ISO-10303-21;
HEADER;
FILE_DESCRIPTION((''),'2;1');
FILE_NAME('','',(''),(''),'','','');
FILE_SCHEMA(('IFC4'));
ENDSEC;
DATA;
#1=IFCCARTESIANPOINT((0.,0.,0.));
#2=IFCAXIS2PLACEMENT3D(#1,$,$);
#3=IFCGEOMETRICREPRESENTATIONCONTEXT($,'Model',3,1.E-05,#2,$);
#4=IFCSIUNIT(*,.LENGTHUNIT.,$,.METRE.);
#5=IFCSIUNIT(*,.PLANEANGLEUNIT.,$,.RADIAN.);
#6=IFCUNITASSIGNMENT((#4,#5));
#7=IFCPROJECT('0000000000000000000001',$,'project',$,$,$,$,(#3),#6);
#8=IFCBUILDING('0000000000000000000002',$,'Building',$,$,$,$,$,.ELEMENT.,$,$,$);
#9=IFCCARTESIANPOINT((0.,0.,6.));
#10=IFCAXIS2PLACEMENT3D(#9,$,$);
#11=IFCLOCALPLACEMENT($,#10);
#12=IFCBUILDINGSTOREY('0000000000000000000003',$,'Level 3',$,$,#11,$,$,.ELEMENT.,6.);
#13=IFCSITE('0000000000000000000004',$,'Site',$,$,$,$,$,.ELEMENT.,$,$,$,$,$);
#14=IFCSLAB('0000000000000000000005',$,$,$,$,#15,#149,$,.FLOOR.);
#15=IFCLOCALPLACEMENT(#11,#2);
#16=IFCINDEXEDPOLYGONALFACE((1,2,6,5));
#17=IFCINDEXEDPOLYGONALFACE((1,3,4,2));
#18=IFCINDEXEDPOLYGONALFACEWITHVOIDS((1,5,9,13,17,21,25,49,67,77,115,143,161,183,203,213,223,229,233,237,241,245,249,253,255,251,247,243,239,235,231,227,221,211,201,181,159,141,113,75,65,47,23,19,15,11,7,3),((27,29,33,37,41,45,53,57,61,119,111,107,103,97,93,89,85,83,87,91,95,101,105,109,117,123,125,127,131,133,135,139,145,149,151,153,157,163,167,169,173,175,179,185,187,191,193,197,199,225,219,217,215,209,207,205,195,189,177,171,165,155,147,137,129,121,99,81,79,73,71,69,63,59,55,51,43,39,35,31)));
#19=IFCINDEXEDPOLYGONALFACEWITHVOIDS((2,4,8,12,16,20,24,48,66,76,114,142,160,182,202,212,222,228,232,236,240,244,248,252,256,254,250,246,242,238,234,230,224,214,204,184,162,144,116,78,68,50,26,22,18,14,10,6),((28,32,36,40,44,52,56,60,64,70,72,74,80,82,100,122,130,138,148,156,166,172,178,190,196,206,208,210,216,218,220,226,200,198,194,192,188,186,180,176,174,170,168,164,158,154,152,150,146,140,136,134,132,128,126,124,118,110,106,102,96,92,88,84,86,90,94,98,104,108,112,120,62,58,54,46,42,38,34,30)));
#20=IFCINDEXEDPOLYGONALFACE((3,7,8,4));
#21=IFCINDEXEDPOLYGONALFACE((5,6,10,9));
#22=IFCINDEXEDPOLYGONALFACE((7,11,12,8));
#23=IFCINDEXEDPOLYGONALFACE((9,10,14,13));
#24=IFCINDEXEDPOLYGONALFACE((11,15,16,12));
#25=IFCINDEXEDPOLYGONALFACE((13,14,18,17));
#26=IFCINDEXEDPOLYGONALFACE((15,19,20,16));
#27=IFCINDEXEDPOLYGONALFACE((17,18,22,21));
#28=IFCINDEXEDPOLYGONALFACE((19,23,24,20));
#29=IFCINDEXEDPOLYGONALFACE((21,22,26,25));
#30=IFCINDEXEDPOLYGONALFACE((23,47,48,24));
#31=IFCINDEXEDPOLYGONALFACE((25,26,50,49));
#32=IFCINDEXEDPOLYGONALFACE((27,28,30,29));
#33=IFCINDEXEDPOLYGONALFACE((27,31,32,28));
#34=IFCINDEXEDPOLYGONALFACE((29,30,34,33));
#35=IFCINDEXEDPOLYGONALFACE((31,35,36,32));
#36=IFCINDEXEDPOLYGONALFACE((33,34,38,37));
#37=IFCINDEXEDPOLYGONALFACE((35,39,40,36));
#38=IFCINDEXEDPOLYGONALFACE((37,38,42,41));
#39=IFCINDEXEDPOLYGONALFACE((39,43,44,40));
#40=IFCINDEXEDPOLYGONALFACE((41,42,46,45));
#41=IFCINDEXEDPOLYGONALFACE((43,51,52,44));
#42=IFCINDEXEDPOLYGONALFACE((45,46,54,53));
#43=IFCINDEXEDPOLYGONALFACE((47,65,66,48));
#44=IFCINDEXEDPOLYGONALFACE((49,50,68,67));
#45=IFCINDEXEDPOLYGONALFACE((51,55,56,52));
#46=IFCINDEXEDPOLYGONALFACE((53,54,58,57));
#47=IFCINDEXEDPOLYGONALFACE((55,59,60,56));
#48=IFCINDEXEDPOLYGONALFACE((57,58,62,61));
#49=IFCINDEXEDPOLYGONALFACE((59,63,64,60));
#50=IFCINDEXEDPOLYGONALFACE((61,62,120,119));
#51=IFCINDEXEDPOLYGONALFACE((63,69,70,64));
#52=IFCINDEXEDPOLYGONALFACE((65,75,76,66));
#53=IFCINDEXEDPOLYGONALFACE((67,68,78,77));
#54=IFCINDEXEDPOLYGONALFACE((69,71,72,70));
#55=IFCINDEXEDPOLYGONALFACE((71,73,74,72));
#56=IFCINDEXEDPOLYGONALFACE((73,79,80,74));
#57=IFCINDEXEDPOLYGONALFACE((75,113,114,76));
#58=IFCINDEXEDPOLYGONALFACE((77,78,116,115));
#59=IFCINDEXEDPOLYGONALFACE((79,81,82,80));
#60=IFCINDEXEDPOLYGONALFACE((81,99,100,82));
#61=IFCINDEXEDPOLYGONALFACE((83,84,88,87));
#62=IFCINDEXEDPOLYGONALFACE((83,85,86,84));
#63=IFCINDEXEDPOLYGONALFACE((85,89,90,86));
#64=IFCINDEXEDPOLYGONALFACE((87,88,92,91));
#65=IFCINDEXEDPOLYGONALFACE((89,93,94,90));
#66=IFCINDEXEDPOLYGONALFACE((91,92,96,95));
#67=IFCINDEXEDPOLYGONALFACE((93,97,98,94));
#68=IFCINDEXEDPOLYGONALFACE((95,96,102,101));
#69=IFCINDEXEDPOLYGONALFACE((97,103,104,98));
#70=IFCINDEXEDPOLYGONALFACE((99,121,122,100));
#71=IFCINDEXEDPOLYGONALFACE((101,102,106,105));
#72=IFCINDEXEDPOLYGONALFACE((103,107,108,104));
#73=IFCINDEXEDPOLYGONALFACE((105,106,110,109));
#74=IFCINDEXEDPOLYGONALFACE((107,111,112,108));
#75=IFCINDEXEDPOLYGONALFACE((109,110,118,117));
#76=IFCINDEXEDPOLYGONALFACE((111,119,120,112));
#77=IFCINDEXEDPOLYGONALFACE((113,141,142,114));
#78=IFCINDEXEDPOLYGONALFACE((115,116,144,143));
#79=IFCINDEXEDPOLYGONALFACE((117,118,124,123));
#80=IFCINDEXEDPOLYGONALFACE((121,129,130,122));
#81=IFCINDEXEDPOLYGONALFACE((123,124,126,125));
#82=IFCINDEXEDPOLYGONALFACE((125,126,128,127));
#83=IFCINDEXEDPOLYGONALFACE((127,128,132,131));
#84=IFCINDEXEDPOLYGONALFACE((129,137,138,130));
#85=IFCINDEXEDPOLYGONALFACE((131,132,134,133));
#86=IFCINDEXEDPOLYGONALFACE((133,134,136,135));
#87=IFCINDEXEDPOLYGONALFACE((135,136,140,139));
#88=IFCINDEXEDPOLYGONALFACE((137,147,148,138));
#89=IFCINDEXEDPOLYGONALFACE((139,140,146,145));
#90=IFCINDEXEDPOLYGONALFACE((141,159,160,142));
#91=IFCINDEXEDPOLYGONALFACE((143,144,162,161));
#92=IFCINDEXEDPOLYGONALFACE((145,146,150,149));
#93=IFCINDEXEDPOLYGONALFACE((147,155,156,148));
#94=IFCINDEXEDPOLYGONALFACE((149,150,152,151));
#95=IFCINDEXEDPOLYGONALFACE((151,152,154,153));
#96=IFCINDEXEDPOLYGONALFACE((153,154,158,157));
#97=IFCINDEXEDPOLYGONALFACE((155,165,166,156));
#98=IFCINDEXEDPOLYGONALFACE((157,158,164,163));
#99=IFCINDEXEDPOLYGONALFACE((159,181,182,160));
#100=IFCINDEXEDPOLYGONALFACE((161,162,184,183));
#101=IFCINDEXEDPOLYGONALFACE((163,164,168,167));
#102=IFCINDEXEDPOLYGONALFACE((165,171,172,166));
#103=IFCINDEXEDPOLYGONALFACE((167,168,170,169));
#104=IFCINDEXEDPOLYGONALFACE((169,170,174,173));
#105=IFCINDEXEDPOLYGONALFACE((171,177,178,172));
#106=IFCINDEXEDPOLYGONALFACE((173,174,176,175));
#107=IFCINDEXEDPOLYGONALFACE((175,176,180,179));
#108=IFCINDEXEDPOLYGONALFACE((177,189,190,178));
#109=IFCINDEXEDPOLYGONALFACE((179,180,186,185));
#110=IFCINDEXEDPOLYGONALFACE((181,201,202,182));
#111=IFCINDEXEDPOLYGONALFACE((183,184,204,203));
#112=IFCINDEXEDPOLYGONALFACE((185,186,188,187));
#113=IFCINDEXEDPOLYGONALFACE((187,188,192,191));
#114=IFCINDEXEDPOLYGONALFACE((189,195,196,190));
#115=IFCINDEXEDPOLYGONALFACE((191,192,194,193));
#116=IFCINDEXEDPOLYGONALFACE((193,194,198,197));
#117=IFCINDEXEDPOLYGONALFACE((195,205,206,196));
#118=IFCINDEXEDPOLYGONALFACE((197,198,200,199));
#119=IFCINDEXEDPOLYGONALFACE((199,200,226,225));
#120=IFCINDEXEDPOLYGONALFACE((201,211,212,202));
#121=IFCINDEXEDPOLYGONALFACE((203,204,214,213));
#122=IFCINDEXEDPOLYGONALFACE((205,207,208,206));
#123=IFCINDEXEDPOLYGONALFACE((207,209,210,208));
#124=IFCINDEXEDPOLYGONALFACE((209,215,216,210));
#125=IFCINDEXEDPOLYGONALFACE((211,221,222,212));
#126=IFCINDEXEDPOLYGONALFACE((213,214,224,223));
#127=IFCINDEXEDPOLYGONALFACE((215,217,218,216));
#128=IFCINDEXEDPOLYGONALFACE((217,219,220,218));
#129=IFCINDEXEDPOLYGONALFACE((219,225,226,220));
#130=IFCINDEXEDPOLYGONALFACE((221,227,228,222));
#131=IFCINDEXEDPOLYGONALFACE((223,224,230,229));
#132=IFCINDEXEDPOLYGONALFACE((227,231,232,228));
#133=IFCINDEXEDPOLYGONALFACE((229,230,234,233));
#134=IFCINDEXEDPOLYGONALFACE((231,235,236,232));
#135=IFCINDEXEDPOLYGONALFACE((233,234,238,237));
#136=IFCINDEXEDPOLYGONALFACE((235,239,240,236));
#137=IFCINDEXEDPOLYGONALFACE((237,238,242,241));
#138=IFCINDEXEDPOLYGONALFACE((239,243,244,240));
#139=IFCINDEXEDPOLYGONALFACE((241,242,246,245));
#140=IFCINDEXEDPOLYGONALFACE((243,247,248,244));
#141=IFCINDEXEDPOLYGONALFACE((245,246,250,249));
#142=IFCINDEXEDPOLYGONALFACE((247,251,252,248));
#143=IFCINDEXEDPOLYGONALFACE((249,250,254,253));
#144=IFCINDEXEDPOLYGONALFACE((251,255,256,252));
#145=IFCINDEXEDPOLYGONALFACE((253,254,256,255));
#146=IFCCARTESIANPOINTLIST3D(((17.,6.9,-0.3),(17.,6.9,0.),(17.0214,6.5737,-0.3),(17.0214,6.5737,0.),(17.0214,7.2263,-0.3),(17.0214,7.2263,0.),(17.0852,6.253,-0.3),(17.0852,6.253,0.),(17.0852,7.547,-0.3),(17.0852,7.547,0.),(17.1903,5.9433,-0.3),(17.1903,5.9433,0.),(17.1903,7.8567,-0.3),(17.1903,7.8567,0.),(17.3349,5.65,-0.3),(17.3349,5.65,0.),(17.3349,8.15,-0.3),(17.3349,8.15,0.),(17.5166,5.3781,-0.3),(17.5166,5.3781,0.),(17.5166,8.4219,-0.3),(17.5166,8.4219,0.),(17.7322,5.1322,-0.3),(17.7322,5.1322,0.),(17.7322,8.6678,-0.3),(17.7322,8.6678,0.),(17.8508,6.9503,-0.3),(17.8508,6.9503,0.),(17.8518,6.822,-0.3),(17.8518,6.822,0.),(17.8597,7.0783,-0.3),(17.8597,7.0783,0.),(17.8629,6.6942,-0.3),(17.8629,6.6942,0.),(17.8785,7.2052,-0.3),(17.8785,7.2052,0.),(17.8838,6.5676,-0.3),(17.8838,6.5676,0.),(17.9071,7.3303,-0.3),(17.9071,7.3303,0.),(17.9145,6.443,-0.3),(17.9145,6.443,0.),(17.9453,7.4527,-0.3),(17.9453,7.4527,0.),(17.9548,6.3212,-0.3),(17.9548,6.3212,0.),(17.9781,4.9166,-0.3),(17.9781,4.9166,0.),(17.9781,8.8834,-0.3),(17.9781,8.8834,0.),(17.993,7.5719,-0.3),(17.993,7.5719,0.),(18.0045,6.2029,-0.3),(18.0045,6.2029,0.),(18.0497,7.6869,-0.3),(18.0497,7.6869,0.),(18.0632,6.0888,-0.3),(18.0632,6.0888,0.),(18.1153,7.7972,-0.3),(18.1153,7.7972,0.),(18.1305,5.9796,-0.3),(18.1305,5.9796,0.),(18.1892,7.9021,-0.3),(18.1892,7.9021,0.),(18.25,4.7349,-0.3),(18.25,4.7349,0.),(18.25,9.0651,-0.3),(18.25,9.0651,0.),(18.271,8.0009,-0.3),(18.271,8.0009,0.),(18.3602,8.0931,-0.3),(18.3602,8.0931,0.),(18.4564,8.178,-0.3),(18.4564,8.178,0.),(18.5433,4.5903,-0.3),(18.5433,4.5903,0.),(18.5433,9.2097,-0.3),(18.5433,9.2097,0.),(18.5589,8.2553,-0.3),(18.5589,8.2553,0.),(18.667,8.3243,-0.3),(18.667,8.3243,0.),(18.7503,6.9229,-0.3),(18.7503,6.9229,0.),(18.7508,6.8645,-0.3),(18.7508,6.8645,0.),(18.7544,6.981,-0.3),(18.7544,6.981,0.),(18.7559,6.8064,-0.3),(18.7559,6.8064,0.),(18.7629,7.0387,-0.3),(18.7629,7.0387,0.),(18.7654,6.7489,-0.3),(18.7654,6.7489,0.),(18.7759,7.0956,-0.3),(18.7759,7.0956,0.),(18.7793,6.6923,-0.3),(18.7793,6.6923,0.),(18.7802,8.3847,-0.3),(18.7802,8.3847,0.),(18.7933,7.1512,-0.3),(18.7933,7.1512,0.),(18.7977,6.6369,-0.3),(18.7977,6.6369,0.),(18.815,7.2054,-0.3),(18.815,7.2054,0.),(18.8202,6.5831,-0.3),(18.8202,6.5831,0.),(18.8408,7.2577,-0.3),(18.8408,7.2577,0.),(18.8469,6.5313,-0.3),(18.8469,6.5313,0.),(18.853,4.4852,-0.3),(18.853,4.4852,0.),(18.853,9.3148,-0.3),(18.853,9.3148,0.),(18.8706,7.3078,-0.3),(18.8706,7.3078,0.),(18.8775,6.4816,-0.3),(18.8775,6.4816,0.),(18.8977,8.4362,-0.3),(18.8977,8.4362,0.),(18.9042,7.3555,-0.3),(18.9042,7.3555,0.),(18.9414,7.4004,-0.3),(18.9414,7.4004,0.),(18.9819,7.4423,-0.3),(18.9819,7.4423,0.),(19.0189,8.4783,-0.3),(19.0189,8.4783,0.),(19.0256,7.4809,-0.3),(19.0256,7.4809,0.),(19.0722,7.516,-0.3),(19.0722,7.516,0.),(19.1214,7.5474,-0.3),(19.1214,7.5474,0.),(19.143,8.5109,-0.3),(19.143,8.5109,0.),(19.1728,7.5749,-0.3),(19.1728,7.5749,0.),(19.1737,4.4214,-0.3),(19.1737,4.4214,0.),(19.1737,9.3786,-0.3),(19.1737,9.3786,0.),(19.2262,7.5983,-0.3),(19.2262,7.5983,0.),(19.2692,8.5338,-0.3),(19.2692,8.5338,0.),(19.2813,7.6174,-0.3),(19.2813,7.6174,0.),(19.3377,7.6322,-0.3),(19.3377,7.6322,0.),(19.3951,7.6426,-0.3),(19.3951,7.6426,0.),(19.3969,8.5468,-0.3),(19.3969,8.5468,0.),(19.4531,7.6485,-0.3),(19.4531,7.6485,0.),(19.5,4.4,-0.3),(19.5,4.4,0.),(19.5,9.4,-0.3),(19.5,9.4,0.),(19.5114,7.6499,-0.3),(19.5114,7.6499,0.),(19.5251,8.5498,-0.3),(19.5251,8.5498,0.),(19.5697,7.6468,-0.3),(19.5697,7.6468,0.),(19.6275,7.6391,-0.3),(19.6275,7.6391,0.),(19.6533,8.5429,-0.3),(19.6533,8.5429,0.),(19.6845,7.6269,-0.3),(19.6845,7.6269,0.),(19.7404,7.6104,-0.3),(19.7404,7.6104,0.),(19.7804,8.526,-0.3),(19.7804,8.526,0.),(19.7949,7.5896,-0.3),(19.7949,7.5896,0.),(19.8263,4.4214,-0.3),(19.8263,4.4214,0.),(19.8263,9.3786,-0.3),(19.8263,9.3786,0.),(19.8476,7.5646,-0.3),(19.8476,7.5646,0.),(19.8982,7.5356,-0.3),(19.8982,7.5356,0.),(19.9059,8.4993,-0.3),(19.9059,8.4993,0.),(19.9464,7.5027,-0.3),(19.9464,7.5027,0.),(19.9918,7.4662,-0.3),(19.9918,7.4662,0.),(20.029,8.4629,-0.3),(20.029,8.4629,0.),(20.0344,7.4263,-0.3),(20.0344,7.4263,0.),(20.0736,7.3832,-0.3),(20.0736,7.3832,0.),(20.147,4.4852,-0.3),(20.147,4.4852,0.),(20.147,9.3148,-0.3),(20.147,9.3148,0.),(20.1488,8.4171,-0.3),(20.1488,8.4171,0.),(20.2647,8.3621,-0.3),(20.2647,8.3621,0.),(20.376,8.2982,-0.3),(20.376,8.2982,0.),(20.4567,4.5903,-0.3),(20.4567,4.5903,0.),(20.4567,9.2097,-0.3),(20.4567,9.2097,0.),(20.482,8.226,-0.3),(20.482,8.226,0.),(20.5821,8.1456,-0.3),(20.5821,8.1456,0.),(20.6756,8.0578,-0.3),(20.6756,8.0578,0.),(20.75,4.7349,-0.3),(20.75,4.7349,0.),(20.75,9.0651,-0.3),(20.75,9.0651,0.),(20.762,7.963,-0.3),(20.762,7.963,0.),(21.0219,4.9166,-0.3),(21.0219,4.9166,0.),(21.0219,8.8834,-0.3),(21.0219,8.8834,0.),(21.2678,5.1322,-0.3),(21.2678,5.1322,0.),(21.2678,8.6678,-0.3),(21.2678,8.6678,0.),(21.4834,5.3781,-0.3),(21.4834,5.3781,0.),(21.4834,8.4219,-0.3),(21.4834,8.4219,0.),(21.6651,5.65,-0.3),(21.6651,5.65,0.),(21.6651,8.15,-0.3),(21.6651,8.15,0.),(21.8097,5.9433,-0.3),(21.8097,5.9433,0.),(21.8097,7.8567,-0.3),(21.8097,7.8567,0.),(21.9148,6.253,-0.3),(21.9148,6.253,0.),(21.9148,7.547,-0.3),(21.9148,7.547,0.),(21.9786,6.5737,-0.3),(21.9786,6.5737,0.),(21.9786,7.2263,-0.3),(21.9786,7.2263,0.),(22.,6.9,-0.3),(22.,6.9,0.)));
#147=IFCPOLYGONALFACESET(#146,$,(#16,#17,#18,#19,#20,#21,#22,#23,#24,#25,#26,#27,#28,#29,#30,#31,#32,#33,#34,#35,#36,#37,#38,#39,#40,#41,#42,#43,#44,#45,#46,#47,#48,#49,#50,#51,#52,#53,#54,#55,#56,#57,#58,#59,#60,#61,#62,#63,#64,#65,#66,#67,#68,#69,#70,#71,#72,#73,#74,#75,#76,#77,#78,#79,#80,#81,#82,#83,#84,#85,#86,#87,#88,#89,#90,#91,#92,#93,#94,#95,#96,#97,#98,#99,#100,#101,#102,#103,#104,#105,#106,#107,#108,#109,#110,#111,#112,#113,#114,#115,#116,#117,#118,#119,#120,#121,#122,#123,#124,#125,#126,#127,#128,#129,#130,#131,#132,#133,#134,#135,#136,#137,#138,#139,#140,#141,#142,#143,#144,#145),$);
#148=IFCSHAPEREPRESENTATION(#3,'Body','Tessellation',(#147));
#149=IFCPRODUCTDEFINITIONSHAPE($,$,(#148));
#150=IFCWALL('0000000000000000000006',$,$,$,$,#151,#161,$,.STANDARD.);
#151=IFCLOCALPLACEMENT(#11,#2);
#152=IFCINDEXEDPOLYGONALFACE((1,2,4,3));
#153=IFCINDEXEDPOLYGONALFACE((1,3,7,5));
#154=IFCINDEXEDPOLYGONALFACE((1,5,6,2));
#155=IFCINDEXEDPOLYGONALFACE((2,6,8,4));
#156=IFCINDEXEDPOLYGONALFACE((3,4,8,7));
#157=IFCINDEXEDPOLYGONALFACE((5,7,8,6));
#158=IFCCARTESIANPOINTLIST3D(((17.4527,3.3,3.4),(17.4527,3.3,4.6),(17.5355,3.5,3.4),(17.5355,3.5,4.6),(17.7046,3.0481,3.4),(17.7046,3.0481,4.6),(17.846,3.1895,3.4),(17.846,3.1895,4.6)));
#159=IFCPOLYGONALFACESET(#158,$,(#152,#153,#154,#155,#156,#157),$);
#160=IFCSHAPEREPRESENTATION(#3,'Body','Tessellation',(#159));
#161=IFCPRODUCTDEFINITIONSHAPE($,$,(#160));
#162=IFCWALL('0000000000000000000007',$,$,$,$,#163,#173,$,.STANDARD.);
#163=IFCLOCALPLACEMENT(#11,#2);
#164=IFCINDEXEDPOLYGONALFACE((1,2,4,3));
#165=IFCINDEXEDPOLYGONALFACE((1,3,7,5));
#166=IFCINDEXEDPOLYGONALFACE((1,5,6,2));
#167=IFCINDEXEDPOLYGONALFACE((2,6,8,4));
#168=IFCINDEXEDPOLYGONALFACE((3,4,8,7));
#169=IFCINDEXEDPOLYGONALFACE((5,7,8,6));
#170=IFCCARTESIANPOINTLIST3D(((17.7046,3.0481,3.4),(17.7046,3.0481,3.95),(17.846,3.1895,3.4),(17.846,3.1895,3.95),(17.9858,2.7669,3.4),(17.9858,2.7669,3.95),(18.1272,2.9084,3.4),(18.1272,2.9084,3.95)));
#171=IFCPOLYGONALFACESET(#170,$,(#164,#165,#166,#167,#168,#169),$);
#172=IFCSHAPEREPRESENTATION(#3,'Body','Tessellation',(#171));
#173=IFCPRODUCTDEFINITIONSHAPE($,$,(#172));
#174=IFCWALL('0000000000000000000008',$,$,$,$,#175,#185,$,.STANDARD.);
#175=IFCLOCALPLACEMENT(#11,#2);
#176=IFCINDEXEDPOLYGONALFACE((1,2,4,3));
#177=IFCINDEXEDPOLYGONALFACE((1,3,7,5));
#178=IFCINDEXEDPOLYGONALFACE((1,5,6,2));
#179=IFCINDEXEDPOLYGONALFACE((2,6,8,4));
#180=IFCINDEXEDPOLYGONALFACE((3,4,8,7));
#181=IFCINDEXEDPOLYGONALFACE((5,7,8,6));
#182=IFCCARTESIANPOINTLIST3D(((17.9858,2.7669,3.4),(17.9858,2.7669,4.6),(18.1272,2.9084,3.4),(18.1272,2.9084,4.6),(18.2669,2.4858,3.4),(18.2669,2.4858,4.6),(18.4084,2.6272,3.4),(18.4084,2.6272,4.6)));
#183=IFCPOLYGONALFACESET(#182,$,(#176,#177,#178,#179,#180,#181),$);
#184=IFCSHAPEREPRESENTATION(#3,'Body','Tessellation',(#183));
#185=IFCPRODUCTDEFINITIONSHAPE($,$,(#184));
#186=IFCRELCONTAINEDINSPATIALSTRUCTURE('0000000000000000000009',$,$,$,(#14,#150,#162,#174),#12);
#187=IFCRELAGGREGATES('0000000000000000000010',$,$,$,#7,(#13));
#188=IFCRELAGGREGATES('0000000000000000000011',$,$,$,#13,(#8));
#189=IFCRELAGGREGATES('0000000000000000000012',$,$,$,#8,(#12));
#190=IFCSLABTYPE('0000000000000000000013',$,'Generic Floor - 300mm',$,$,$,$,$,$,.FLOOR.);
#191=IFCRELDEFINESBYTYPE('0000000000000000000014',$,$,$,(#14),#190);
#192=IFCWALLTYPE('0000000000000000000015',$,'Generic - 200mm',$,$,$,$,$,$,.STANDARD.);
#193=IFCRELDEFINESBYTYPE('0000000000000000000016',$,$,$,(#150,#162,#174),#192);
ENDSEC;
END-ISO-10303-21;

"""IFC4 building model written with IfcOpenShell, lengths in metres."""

from ifc_helpers import new_model, si_unit, frame, frame_2d, origin, place, context, project, spatial, polyline, rectangle, outline, extrude, type_object, element, save


model = new_model("IFC4")

# Units and contexts
model_context = context("Model", 3, precision=1e-05, world=origin())
ifc_project = project(units=[si_unit("LENGTHUNIT", "METRE"), si_unit("PLANEANGLEUNIT", "RADIAN")], contexts=[model_context])

# Site, building, storey
site = spatial("IfcSite", under=ifc_project, Name="Site", CompositionType="ELEMENT")
building = spatial("IfcBuilding", under=site, Name="Building", CompositionType="ELEMENT")
storey_placement = place(None, frame((0.0, 0.0, 6.0)))
storey = spatial("IfcBuildingStorey", under=building, at=storey_placement, Name="Level 3", CompositionType="ELEMENT", Elevation=6.0)

# Shared definitions
slab_type = type_object("IfcSlabType", Name="Generic Floor - 300mm", PredefinedType="FLOOR")

# Slab, opening
slab_1_placement = place(None, frame((0.0, 0.0, 6.0)))
slab_1 = element("IfcSlab", 1, at=slab_1_placement, inside=storey, type_object=slab_type, PredefinedType="FLOOR", context=model_context, shape_type="SweptSolid", body=[
    extrude(outline(polyline([(22.0, 6.9), (21.9786, 7.2263), (21.9148, 7.547), (21.8097, 7.8567), (21.6651, 8.15), (21.4834, 8.4219), (21.2678, 8.6678), (21.0219, 8.8834), (20.75, 9.0651), (20.4567, 9.2097), (20.147, 9.3148), (19.8263, 9.3786), (19.5, 9.4), (19.1737, 9.3786), (18.853, 9.3148), (18.5433, 9.2097), (18.25, 9.0651), (17.9781, 8.8834), (17.7322, 8.6678), (17.5166, 8.4219), (17.3349, 8.15), (17.1903, 7.8567), (17.0852, 7.547), (17.0214, 7.2263), (17.0, 6.9), (17.0214, 6.5737), (17.0852, 6.253), (17.1903, 5.9433), (17.3349, 5.65), (17.5166, 5.3781), (17.7322, 5.1322), (17.9781, 4.9166), (18.25, 4.7349), (18.5433, 4.5903), (18.853, 4.4852), (19.1737, 4.4214), (19.5, 4.4), (19.8263, 4.4214), (20.147, 4.4852), (20.4567, 4.5903), (20.75, 4.7349), (21.0219, 4.9166), (21.2678, 5.1322), (21.4834, 5.3781), (21.6651, 5.65), (21.8097, 5.9433), (21.9148, 6.253), (21.9786, 6.5737), (22.0, 6.9)])), origin(), (0.0, 0.0, -1.0), 0.3),
])
opening_1_placement = place(None, frame((0.0, 0.0, 6.001)))
element("IfcOpeningElement", 2, at=opening_1_placement, cuts=slab_1, PredefinedType="OPENING", context=model_context, shape_type="SweptSolid", body=[
    extrude(outline(polyline([(17.8597, 7.0783), (17.8508, 6.9503), (17.8518, 6.822), (17.8629, 6.6942), (17.8838, 6.5676), (17.9145, 6.443), (17.9548, 6.3212), (18.0045, 6.2029), (18.0632, 6.0888), (18.1305, 5.9796), (18.8775, 6.4816), (18.8469, 6.5313), (18.8202, 6.5831), (18.7977, 6.6369), (18.7793, 6.6923), (18.7654, 6.7489), (18.7559, 6.8064), (18.7508, 6.8645), (18.7503, 6.9229), (18.7544, 6.981), (18.7629, 7.0387), (18.7759, 7.0956), (18.7933, 7.1512), (18.815, 7.2054), (18.8408, 7.2577), (18.8706, 7.3078), (18.9042, 7.3555), (18.9414, 7.4004), (18.9819, 7.4423), (19.0256, 7.4809), (19.0722, 7.516), (19.1214, 7.5474), (19.1728, 7.5749), (19.2262, 7.5983), (19.2813, 7.6174), (19.3377, 7.6322), (19.3951, 7.6426), (19.4531, 7.6485), (19.5114, 7.6499), (19.5697, 7.6468), (19.6275, 7.6391), (19.6845, 7.6269), (19.7404, 7.6104), (19.7949, 7.5896), (19.8476, 7.5646), (19.8982, 7.5356), (19.9464, 7.5027), (19.9918, 7.4662), (20.0344, 7.4263), (20.0736, 7.3832), (20.762, 7.963), (20.6756, 8.0578), (20.5821, 8.1456), (20.482, 8.226), (20.376, 8.2982), (20.2647, 8.3621), (20.1488, 8.4171), (20.029, 8.4629), (19.9059, 8.4993), (19.7804, 8.526), (19.6533, 8.5429), (19.5251, 8.5498), (19.3969, 8.5468), (19.2692, 8.5338), (19.143, 8.5109), (19.0189, 8.4783), (18.8977, 8.4362), (18.7802, 8.3847), (18.667, 8.3243), (18.5589, 8.2553), (18.4564, 8.178), (18.3602, 8.0931), (18.271, 8.0009), (18.1892, 7.9021), (18.1153, 7.7972), (18.0497, 7.6869), (17.993, 7.5719), (17.9453, 7.4527), (17.9071, 7.3303), (17.8785, 7.2052), (17.8597, 7.0783)])), origin(), (0.0, 0.0, -1.0), 0.302),
])

# Walls
wall_type = type_object("IfcWallType", Name="Generic - 200mm", PredefinedType="STANDARD")
wall_1_placement = place(None, frame((17.4941, 3.4, 9.4), z_axis=(0.0, 0.0, 1.0), x_axis=(0.707107, -0.707107, 0.0)))
element("IfcWall", 3, at=wall_1_placement, inside=storey, type_object=wall_type, PredefinedType="STANDARD", context=model_context, shape_type="SweptSolid", body=[
    extrude(outline(polyline([(0.0414, -0.1), (0.3976, -0.1), (0.3976, 0.1), (-0.0414, 0.1), (0.0414, -0.1)])), origin(), (0.0, 0.0, 1.0), 1.2),
])
wall_2_placement = place(None, frame((17.7753, 3.1188, 9.4), z_axis=(0.0, 0.0, 1.0), x_axis=(0.707107, -0.707107, 0.0)))
element("IfcWall", 4, at=wall_2_placement, inside=storey, type_object=wall_type, PredefinedType="STANDARD", context=model_context, shape_type="SweptSolid", body=[
    extrude(rectangle(XDim=0.3976, YDim=0.2, at=frame_2d((0.1988, 0.0))), origin(), (0.0, 0.0, 1.0), 0.55),
])
wall_3_placement = place(None, frame((18.0565, 2.8376, 9.4), z_axis=(0.0, 0.0, 1.0), x_axis=(0.707107, -0.707107, 0.0)))
element("IfcWall", 5, at=wall_3_placement, inside=storey, type_object=wall_type, PredefinedType="STANDARD", context=model_context, shape_type="SweptSolid", body=[
    extrude(rectangle(XDim=0.3976, YDim=0.2, at=frame_2d((0.1988, 0.0))), origin(), (0.0, 0.0, 1.0), 1.2),
])

save(model, "model.ifc")
